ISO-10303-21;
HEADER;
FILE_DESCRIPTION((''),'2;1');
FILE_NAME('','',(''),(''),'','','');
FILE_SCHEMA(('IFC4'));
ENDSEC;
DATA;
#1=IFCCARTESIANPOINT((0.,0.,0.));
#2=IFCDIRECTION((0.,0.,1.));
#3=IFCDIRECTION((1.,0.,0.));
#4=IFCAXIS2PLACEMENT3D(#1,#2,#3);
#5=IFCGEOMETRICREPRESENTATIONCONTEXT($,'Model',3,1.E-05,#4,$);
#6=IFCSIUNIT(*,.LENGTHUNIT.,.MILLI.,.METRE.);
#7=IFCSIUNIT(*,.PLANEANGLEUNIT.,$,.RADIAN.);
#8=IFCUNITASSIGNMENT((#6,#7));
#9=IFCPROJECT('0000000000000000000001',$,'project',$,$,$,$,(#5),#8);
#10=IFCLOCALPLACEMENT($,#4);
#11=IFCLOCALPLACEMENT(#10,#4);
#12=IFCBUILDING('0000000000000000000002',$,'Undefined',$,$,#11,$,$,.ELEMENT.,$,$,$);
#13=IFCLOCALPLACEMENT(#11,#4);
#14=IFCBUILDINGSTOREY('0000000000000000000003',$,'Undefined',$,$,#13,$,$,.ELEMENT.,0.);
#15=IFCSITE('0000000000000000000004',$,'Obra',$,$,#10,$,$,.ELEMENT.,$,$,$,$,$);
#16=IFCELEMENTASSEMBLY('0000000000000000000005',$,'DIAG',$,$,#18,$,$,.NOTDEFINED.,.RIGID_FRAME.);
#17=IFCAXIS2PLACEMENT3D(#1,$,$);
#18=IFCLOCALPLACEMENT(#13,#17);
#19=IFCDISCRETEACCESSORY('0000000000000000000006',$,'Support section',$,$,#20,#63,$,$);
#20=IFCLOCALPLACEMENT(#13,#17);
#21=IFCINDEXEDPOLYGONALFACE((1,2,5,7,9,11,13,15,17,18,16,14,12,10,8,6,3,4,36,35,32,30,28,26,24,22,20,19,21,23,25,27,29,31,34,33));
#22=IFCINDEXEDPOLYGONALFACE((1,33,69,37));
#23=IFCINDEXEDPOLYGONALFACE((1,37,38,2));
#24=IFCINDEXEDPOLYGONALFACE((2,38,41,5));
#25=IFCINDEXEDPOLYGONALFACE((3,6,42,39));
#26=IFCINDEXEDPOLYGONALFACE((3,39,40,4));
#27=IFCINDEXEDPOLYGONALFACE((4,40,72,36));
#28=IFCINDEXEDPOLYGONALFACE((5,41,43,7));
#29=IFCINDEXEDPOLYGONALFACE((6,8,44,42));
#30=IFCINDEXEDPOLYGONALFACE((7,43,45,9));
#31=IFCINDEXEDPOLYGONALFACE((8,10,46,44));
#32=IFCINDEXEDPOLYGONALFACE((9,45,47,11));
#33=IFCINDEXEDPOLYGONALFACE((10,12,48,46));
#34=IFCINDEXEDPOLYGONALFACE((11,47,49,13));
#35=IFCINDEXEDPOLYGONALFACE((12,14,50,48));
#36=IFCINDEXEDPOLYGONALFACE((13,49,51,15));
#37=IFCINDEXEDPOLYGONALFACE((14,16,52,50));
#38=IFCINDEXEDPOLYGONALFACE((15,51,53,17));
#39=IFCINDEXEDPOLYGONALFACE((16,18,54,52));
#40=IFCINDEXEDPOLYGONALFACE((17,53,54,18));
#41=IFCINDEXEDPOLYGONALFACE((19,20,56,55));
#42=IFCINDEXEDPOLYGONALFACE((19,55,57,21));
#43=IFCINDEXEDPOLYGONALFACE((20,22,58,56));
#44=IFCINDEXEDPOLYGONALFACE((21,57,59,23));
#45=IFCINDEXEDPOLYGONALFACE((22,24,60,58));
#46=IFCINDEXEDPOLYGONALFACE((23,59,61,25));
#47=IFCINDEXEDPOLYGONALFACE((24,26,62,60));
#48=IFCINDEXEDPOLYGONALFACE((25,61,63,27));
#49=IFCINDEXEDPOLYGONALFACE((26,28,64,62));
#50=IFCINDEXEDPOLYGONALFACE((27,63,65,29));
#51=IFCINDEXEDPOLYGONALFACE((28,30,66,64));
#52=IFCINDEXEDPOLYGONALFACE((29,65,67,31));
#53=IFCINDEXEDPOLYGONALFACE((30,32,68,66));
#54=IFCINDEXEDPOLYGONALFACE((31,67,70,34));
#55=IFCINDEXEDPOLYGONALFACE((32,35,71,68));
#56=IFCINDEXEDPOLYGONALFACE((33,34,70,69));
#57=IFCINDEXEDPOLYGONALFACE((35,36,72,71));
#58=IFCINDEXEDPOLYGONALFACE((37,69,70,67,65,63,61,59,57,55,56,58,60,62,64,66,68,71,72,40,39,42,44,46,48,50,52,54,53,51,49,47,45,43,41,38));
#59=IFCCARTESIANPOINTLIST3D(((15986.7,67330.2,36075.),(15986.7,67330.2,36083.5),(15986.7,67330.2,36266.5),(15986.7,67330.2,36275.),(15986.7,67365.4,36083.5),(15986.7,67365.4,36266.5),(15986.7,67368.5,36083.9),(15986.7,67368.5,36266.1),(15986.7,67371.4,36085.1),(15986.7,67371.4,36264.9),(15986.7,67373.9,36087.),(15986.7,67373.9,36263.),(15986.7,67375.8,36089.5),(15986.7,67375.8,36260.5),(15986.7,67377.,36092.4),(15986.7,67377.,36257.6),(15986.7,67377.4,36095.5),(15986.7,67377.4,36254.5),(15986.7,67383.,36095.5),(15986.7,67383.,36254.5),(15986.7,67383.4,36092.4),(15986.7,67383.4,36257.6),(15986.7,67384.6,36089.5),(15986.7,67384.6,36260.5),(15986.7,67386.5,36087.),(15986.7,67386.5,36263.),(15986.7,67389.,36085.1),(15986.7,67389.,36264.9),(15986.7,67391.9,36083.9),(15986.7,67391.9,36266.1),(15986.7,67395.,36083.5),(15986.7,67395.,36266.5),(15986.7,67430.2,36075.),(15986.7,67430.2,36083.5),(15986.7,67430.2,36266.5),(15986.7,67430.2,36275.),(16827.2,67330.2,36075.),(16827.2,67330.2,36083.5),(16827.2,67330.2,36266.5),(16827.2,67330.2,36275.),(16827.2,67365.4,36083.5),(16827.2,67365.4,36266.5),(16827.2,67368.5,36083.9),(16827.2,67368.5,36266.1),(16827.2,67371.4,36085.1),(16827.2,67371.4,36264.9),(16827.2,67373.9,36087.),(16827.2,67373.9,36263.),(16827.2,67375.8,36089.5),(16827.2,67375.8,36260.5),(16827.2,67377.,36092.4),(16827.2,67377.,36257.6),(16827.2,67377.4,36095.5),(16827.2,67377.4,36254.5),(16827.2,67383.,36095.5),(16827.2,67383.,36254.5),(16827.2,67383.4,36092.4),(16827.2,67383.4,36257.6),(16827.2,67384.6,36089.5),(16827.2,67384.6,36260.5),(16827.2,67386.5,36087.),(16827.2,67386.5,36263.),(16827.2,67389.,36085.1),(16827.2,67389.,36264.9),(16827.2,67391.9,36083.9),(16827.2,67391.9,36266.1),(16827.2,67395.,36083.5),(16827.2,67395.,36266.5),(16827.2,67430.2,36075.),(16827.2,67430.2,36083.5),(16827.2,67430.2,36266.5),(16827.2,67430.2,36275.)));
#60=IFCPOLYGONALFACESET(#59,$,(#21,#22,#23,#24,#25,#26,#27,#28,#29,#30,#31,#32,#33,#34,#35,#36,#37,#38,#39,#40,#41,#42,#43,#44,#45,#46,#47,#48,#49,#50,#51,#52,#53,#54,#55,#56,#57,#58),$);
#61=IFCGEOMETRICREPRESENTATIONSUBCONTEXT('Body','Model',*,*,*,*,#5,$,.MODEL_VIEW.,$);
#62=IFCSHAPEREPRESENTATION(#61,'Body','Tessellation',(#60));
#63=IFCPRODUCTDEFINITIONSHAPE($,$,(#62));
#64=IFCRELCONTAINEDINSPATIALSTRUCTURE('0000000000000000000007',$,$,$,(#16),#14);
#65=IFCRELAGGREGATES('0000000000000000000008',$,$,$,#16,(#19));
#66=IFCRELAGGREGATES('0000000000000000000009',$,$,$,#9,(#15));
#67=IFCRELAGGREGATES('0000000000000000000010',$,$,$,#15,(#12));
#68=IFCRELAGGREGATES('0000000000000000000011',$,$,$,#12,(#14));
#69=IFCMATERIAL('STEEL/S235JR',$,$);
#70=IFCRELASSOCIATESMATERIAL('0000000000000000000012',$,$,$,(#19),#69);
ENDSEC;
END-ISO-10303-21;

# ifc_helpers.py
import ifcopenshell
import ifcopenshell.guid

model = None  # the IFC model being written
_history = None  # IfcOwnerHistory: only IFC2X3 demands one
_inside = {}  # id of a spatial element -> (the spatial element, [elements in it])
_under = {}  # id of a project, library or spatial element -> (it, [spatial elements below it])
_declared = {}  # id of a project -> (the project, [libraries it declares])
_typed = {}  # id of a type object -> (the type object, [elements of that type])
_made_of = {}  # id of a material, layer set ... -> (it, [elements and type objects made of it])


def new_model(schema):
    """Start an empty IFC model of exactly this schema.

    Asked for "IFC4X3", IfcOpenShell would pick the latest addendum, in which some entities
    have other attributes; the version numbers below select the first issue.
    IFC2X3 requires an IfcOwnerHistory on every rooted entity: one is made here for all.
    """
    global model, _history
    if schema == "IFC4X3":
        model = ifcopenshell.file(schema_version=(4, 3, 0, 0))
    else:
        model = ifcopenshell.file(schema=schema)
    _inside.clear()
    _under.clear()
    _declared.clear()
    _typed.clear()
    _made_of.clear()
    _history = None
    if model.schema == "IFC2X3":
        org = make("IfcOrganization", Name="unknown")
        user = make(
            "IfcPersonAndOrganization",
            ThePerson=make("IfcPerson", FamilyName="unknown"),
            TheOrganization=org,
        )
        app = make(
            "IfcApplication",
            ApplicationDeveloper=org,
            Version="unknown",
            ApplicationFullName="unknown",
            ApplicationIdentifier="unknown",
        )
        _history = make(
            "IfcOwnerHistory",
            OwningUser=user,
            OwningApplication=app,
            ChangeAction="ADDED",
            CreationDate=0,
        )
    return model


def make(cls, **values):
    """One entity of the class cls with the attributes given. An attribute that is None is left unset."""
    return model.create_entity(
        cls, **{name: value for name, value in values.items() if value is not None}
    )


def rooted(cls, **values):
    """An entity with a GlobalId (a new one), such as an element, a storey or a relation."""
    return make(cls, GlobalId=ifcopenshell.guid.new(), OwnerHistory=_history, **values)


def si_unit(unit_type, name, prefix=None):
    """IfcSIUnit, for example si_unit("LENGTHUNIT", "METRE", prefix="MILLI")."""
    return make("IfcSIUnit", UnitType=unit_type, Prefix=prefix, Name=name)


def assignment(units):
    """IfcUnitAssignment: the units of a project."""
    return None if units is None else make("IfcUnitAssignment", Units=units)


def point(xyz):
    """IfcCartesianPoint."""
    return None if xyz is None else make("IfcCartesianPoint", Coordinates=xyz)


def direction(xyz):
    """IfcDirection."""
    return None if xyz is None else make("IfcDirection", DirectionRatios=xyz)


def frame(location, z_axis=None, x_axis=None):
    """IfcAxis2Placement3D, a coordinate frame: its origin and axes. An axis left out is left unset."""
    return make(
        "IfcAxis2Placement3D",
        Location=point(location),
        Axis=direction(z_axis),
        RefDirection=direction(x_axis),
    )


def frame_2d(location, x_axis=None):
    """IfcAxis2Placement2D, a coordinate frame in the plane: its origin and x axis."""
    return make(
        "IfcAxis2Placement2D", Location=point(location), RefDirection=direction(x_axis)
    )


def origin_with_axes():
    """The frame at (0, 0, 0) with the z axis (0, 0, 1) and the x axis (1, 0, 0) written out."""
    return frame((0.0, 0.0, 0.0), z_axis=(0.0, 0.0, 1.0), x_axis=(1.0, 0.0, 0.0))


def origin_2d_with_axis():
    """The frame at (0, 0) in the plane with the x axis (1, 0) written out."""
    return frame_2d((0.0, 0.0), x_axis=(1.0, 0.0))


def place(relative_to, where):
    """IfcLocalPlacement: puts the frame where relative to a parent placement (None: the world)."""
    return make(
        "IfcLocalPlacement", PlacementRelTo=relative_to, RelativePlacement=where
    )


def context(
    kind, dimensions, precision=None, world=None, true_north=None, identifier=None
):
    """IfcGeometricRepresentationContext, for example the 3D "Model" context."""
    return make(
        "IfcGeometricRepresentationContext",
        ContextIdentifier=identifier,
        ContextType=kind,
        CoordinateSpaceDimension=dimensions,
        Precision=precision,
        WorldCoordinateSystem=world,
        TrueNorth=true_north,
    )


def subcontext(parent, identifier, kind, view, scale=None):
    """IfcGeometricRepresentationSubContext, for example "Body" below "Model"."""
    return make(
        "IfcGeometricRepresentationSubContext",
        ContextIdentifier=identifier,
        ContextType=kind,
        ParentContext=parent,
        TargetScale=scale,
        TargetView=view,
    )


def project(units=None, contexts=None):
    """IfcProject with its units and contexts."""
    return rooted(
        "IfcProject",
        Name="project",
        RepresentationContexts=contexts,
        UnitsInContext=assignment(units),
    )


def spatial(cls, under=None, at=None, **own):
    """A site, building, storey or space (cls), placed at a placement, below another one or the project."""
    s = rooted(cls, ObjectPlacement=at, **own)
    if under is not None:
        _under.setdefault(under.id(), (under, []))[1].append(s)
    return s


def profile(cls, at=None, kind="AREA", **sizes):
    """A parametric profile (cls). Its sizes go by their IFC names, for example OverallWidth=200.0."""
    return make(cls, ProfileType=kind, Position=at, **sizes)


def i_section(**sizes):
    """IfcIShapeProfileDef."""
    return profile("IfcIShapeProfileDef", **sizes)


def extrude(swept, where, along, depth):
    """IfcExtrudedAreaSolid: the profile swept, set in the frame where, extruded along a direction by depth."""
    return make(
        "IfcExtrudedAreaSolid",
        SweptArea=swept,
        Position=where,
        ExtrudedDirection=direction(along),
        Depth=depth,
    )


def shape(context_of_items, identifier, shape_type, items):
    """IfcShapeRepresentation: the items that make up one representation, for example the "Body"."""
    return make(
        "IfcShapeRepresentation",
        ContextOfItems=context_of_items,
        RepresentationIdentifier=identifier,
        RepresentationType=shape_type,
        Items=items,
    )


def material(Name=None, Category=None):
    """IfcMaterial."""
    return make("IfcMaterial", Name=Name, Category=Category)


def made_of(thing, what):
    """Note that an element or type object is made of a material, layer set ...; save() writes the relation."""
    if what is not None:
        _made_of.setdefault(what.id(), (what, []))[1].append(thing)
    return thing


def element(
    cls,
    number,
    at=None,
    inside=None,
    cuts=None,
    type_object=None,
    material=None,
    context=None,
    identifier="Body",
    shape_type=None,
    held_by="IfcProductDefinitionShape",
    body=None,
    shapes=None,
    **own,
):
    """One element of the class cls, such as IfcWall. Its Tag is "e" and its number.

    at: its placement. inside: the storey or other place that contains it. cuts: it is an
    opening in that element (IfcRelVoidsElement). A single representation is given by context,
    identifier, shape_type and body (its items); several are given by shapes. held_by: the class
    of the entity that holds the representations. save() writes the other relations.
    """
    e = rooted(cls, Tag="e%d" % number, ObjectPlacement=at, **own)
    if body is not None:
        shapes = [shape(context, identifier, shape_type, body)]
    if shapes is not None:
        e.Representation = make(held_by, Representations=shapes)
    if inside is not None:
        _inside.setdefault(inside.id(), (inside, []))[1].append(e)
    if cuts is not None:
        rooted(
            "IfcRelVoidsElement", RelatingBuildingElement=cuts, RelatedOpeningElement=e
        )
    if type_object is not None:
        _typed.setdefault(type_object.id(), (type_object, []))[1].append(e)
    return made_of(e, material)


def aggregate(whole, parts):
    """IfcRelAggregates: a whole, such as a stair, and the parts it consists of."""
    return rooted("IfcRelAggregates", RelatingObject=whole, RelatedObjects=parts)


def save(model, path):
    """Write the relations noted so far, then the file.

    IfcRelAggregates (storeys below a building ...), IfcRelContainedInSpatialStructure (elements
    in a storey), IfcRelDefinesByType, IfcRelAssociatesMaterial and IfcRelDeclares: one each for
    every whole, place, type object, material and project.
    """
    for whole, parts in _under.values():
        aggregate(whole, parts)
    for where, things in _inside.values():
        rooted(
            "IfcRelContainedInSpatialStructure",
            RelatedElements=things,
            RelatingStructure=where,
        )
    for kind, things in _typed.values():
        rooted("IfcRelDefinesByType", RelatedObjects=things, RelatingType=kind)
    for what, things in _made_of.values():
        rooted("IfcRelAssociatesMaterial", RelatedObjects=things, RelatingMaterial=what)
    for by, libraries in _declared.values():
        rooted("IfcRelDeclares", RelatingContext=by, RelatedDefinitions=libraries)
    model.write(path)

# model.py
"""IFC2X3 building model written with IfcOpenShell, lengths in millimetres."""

from ifc_helpers import new_model, si_unit, frame, origin_with_axes, origin_2d_with_axis, place, context, subcontext, project, spatial, i_section, extrude, material, element, aggregate, save


model = new_model("IFC2X3")

# Units and contexts
model_context = context("Model", 3, precision=1e-05, world=origin_with_axes())
body_context = subcontext(model_context, "Body", "Model", "MODEL_VIEW")
ifc_project = project(units=[si_unit("LENGTHUNIT", "METRE", prefix="MILLI"), si_unit("PLANEANGLEUNIT", "RADIAN")], contexts=[model_context])

# Site, building, storey
site_placement = place(None, origin_with_axes())
site = spatial("IfcSite", under=ifc_project, at=site_placement, Name="Obra", CompositionType="ELEMENT")
building_placement = place(site_placement, origin_with_axes())
building = spatial("IfcBuilding", under=site, at=building_placement, Name="Undefined", CompositionType="ELEMENT")
storey_placement = place(building_placement, origin_with_axes())
storey = spatial("IfcBuildingStorey", under=building, at=storey_placement, Name="Undefined", CompositionType="ELEMENT", Elevation=0.0)

# Element assembly
ifc_material_1 = material(Name="STEEL/S235JR")
assembly_1_placement = place(storey_placement, origin_with_axes())
assembly_1 = element("IfcElementAssembly", 1, at=assembly_1_placement, inside=storey, Name="DIAG", AssemblyPlace="NOTDEFINED", PredefinedType="RIGID_FRAME")

# Discrete accessory
discrete_accessory_1_placement = place(assembly_1_placement, frame((16827.2, 67380.2, 36175.0), z_axis=(0.0, 0.0, 1.0), x_axis=(-1.0, 0.0, 0.0)))
discrete_accessory_1 = element("IfcDiscreteAccessory", 2, at=discrete_accessory_1_placement, material=ifc_material_1, Name="Support section", context=body_context, shape_type="SweptSolid", body=[
    extrude(i_section(OverallWidth=100.0, OverallDepth=200.0, WebThickness=5.6, FlangeThickness=8.5, FilletRadius=12.0, at=origin_2d_with_axis()), frame((840.5, 0.0, 0.0), z_axis=(-1.0, 0.0, 0.0), x_axis=(0.0, -1.0, 0.0)), (0.0, 0.0, 1.0), 840.5),
])
aggregate(assembly_1, [discrete_accessory_1])

save(model, "model.ifc")
